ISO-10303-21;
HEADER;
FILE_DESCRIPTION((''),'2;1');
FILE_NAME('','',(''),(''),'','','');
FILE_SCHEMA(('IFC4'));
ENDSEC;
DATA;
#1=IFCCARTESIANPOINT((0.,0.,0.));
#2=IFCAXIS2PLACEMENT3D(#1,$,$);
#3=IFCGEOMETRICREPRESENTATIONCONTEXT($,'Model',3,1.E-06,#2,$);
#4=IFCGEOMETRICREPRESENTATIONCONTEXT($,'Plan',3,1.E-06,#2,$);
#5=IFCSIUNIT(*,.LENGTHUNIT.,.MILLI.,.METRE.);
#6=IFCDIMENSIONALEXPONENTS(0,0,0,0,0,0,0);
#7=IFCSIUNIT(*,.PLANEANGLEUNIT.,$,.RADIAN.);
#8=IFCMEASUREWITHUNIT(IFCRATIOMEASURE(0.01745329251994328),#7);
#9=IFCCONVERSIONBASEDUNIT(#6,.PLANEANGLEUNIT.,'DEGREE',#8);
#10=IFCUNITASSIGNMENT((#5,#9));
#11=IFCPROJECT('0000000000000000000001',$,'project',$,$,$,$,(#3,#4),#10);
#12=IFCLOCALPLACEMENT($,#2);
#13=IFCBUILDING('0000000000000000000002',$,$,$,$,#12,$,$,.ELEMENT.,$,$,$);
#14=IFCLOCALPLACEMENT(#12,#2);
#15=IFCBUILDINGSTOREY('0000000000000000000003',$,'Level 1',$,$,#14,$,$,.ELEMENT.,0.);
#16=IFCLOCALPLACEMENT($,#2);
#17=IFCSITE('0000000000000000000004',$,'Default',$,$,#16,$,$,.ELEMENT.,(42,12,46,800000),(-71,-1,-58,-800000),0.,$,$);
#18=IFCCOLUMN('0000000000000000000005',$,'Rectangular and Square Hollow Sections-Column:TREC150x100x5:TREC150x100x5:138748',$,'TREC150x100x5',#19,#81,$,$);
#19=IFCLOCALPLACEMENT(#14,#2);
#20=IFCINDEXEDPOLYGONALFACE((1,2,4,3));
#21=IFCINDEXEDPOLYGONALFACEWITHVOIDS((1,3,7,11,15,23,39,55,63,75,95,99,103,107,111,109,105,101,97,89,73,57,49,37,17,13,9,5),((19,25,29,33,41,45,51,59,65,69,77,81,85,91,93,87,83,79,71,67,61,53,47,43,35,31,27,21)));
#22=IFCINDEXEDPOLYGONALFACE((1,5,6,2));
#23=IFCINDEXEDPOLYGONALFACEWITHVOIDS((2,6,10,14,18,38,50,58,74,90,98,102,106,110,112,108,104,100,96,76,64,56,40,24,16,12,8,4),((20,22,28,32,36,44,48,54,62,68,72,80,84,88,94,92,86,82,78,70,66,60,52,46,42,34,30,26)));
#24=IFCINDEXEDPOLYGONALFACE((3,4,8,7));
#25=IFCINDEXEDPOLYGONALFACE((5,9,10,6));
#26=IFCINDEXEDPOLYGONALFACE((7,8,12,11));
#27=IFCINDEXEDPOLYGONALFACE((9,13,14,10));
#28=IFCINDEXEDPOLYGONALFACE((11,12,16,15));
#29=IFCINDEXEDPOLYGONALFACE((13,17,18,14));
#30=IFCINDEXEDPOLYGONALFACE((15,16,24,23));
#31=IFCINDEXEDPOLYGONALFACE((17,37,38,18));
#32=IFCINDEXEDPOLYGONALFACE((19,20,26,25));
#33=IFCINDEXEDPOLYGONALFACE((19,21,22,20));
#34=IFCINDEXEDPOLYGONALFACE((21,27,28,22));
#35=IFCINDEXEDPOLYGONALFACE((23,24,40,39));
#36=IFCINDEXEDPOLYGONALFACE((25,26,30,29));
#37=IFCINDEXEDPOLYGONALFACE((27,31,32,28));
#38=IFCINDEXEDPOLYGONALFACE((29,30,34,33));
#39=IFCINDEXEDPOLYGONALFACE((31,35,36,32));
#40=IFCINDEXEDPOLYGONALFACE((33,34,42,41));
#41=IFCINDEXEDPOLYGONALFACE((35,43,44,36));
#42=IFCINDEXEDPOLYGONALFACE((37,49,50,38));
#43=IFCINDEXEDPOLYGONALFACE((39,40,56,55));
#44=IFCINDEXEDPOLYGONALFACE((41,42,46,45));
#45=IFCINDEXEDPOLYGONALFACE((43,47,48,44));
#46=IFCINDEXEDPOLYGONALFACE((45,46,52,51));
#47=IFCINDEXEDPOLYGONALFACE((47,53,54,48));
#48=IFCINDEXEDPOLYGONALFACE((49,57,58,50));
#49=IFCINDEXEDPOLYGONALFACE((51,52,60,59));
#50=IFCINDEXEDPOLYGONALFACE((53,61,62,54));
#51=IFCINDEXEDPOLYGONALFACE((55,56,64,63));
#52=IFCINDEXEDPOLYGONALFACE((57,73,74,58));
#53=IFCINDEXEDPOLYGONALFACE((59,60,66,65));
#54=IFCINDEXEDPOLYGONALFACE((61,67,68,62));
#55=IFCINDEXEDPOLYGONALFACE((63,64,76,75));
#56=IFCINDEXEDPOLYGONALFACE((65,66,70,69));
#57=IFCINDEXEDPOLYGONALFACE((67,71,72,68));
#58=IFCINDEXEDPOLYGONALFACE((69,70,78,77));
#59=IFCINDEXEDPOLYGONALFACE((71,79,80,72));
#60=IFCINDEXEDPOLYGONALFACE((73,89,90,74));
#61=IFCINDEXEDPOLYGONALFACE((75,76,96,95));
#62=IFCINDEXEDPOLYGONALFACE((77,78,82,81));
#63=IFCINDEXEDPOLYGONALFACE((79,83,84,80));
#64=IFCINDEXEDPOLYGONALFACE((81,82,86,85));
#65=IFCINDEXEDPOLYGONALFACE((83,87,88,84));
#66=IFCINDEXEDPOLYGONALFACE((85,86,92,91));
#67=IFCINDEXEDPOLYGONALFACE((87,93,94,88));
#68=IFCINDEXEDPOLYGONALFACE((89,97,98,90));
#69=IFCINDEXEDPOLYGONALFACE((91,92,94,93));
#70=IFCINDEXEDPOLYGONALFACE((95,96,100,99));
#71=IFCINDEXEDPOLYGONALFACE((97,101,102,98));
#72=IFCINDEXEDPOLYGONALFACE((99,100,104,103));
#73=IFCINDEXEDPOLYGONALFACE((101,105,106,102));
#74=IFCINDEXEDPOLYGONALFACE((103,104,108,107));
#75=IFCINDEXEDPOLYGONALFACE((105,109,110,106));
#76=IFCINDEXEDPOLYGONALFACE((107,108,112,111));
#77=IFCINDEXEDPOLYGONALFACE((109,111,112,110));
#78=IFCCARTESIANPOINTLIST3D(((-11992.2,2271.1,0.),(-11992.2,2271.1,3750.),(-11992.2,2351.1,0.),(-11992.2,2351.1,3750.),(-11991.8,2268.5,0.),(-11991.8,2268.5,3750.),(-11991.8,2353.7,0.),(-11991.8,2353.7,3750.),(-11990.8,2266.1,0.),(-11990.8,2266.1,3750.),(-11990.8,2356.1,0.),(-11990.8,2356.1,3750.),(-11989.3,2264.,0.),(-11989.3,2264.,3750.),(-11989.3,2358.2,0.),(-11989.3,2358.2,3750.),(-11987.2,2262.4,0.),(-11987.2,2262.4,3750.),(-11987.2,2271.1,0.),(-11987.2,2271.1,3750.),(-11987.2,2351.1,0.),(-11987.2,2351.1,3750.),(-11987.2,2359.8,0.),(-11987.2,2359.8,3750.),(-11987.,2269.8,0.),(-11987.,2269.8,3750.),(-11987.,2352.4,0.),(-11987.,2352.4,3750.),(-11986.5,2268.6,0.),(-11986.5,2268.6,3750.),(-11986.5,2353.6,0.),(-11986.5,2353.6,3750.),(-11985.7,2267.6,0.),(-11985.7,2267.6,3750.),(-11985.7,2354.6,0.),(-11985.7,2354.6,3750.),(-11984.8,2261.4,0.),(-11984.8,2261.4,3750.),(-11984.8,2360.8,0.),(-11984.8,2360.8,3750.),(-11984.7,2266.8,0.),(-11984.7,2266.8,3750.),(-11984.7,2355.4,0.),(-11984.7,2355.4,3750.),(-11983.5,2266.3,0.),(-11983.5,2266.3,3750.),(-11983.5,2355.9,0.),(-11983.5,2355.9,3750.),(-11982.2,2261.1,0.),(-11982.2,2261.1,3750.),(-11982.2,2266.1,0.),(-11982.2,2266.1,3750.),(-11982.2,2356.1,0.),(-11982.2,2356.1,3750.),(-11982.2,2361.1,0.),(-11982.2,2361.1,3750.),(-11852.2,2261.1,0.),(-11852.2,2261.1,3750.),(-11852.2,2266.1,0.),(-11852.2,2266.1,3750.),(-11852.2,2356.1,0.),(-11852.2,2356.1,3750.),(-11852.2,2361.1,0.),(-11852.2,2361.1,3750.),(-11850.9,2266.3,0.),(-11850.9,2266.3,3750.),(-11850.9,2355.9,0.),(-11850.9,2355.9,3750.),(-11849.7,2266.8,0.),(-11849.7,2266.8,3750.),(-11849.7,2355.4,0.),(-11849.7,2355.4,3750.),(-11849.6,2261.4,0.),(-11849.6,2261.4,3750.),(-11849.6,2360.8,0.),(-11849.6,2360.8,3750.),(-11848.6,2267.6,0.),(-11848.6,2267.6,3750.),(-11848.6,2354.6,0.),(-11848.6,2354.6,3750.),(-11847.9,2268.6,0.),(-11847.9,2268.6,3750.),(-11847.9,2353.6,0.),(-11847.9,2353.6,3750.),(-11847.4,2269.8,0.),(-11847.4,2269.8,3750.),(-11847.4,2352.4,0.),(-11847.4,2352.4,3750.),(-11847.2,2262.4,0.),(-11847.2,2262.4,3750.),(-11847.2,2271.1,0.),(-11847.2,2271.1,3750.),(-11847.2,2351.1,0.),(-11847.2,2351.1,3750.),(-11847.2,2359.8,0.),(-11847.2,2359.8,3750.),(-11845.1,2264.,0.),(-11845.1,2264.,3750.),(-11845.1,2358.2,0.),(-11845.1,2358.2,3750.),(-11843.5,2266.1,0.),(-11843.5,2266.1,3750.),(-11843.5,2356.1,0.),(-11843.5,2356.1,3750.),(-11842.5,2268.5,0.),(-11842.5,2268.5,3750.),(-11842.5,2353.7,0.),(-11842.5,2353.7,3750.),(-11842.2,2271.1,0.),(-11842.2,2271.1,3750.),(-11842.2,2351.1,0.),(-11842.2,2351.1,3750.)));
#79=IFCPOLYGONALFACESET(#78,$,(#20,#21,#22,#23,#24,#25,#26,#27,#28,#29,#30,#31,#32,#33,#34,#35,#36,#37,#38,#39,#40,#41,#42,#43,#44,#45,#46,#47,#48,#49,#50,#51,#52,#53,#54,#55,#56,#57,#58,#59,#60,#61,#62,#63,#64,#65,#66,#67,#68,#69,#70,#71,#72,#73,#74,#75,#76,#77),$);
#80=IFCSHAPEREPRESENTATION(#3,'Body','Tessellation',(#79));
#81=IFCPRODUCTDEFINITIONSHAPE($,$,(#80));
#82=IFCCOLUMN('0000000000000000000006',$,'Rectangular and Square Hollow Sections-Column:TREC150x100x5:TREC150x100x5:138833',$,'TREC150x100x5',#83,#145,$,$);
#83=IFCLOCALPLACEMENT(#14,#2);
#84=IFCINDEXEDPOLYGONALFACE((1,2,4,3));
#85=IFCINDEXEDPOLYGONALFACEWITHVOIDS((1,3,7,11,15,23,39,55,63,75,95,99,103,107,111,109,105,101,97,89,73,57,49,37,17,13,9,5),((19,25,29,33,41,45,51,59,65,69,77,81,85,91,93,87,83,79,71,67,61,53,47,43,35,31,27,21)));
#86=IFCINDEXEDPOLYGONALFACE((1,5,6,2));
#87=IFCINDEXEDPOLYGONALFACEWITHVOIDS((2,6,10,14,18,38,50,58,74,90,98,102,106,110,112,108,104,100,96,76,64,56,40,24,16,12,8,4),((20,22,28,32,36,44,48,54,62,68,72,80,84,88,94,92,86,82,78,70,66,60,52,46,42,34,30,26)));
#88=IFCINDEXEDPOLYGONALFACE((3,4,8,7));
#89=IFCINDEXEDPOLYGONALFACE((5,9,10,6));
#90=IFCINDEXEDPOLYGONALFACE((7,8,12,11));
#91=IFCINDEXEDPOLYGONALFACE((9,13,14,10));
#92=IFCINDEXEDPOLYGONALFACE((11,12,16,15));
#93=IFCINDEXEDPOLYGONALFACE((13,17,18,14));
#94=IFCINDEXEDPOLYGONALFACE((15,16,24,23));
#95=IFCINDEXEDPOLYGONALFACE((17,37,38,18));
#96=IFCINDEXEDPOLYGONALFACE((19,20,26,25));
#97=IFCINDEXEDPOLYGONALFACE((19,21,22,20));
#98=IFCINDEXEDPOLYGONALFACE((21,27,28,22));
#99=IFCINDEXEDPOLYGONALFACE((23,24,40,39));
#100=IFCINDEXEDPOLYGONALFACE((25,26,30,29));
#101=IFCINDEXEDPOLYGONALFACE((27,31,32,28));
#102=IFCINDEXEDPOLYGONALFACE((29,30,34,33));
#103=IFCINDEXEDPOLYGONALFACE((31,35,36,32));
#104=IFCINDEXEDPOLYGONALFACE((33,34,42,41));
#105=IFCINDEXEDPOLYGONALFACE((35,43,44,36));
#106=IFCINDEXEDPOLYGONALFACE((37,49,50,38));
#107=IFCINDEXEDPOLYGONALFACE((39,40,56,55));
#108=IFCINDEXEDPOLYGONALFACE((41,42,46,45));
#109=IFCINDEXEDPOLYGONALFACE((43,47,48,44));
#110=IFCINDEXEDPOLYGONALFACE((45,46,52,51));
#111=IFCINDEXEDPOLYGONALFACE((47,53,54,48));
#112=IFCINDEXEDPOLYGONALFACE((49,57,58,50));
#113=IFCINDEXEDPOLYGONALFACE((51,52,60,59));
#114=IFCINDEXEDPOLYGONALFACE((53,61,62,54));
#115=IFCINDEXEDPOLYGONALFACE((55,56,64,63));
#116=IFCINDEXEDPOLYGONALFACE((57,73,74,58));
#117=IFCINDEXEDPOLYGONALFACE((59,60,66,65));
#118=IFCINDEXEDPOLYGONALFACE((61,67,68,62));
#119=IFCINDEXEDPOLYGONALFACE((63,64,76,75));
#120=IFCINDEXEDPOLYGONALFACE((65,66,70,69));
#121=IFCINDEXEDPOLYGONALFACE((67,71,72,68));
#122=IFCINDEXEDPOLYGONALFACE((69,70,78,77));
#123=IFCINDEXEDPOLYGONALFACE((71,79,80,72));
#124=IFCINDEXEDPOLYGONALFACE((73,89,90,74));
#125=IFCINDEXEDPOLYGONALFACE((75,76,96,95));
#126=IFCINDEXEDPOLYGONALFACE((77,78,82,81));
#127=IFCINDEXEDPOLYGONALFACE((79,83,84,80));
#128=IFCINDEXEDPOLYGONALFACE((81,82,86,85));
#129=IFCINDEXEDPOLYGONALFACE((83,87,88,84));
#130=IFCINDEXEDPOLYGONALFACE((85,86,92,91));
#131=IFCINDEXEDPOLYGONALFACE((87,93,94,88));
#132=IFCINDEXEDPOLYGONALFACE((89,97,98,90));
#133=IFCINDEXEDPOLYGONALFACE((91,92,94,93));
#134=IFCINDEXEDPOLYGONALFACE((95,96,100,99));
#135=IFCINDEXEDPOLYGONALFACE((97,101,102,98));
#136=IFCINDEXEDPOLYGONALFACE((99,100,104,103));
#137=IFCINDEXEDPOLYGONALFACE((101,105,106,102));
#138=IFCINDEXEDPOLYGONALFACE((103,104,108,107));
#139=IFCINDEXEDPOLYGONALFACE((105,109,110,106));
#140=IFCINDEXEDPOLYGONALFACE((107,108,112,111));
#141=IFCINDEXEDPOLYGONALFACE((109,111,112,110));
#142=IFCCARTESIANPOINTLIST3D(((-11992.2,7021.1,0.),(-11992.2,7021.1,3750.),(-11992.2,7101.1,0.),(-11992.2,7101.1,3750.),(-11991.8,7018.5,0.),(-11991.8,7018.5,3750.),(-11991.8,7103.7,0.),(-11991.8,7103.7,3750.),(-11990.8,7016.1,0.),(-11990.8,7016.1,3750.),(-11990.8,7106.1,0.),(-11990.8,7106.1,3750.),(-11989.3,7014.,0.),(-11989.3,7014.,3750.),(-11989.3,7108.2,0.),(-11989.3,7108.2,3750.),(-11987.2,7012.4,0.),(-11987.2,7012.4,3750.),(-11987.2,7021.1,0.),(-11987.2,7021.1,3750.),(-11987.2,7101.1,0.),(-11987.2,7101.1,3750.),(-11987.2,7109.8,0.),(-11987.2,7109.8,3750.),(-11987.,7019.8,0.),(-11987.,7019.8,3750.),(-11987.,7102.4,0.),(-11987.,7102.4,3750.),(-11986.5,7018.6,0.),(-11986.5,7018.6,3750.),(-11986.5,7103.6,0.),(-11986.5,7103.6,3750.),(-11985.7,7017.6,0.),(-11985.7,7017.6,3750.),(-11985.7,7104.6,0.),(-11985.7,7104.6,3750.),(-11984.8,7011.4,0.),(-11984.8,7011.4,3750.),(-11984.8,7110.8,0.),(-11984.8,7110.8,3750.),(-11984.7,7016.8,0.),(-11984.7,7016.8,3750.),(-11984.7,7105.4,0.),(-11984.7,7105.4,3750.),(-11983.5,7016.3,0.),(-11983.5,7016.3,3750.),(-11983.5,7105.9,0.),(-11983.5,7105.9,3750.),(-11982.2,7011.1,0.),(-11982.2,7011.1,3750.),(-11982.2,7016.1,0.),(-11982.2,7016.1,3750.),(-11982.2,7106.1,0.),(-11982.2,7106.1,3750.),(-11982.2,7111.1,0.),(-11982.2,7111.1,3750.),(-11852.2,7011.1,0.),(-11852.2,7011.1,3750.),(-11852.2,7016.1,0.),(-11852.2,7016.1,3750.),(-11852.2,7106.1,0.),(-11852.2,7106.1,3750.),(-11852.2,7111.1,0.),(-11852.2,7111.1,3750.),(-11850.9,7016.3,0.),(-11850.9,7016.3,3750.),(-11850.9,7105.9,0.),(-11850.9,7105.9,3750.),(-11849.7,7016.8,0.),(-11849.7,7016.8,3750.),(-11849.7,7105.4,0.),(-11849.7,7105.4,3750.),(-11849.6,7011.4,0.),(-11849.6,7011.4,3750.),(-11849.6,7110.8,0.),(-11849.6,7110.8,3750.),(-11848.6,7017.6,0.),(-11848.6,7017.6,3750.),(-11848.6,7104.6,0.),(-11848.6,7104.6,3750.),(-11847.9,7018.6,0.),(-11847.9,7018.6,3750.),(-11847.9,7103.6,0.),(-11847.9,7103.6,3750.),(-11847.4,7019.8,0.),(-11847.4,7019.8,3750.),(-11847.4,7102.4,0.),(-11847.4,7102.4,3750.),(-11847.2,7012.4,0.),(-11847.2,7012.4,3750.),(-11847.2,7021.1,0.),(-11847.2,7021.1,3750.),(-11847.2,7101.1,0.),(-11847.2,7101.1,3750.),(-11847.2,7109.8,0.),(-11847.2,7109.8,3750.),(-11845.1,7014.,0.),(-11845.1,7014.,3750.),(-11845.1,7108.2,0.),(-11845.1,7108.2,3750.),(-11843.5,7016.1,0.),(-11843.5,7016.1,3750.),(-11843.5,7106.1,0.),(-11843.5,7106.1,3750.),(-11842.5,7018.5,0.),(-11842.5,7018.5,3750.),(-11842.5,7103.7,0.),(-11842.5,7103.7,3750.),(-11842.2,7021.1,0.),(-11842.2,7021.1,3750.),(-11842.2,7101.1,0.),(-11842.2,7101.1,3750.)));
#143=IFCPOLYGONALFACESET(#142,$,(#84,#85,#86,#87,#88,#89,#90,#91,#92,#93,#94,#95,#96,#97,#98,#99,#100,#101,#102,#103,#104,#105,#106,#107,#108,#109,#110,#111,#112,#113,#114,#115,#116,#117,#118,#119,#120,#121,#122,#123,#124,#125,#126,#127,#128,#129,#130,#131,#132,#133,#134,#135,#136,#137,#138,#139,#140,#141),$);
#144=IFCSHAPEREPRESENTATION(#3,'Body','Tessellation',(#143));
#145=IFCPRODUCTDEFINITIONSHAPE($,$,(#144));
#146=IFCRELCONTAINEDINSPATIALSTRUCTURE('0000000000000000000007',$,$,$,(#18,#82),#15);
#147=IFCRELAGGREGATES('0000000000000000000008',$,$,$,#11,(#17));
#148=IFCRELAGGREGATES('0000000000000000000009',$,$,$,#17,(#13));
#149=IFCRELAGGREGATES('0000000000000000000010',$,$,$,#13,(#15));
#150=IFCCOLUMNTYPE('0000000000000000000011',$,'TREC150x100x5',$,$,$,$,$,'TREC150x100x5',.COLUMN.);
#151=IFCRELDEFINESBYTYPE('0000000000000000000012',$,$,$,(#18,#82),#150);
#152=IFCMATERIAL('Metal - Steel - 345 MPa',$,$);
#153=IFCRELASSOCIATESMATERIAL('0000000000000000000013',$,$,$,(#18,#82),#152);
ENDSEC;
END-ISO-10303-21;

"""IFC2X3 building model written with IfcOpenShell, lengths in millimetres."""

from ifc_helpers import new_model, entity, si_unit, converted_unit, frame, frame_2d, origin, place, context, project, spatial, polyline, circle_curve, parameter, trimmed, segment, composite_curve, outline, extrude, source, transform, mapped, material, type_object, type_shapes, element, save


model = new_model("IFC2X3")

# Units and contexts
model_context = context("Model", 3, precision=1e-06, world=origin())
plan_context = context("Plan", 3, precision=1e-06, world=origin())
ifc_project = project(units=[si_unit("LENGTHUNIT", "METRE", prefix="MILLI"), converted_unit("PLANEANGLEUNIT", "DEGREE", entity("IfcRatioMeasure", 0.01745329251994328), si_unit("PLANEANGLEUNIT", "RADIAN"), dimensions=[0, 0, 0, 0, 0, 0, 0])], contexts=[model_context, plan_context])

# Site, building, storey
site_placement = place(None, origin())
site = spatial("IfcSite", under=ifc_project, at=site_placement, Name="Default", CompositionType="ELEMENT", RefLatitude=(42, 12, 46, 800000), RefLongitude=(-71, -1, -58, -800000), RefElevation=0.0)
building_placement = place(None, origin())
building = spatial("IfcBuilding", under=site, at=building_placement, CompositionType="ELEMENT")
storey_placement = place(building_placement, origin())
storey = spatial("IfcBuildingStorey", under=building, at=storey_placement, Name="Level 1", CompositionType="ELEMENT", Elevation=0.0)

# Columns
ifc_material_1 = material(Name="Metal - Steel - 345 MPa")
column_type_1 = type_object("IfcColumnType", Name="TREC150x100x5", ElementType="TREC150x100x5", PredefinedType="COLUMN")
shared_shape_1 = source(origin(), model_context, "Body", "SweptSolid", [
    extrude(outline(composite_curve([segment(polyline([(-40.0, -75.0), (40.0, -75.0)]), True, "CONTINUOUS"), segment(trimmed(circle_curve(frame_2d((40.0, -65.0), x_axis=(-1.0, 0.0)), 10.0), [parameter(90.0)], [parameter(180.0)], True, "PARAMETER"), True, "CONTINUOUS"), segment(polyline([(50.0, -65.0), (50.0, 65.0)]), True, "CONTINUOUS"), segment(trimmed(circle_curve(frame_2d((40.0, 65.0), x_axis=(-1.0, 0.0)), 10.0), [parameter(180.0)], [parameter(270.0)], True, "PARAMETER"), True, "CONTINUOUS"), segment(polyline([(40.0, 75.0), (-40.0, 75.0)]), True, "CONTINUOUS"), segment(trimmed(circle_curve(frame_2d((-40.0, 65.0), x_axis=(-1.0, 0.0)), 10.0), [parameter(270.0)], [parameter(360.0)], True, "PARAMETER"), True, "CONTINUOUS"), segment(polyline([(-50.0, 65.0), (-50.0, -65.0)]), True, "CONTINUOUS"), segment(trimmed(circle_curve(frame_2d((-40.0, -65.0), x_axis=(-1.0, 0.0)), 10.0), [parameter(360.0)], [parameter(90.0)], True, "PARAMETER"), True, "CONTINUOUS")], self_intersect=False), holes=[composite_curve([segment(trimmed(circle_curve(frame_2d((-40.0, -65.0), x_axis=(-1.0, 0.0)), 5.0), [parameter(0.0)], [parameter(90.0)], True, "PARAMETER"), False, "CONTINUOUS"), segment(polyline([(-45.0, -65.0), (-45.0, 65.0)]), True, "CONTINUOUS"), segment(trimmed(circle_curve(frame_2d((-40.0, 65.0), x_axis=(-1.0, 0.0)), 5.0), [parameter(270.0)], [parameter(360.0)], True, "PARAMETER"), False, "CONTINUOUS"), segment(polyline([(-40.0, 70.0), (40.0, 70.0)]), True, "CONTINUOUS"), segment(trimmed(circle_curve(frame_2d((40.0, 65.0), x_axis=(-1.0, 0.0)), 5.0), [parameter(180.0)], [parameter(270.0)], True, "PARAMETER"), False, "CONTINUOUS"), segment(polyline([(45.0, 65.0), (45.0, -65.0)]), True, "CONTINUOUS"), segment(trimmed(circle_curve(frame_2d((40.0, -65.0), x_axis=(-1.0, 0.0)), 5.0), [parameter(90.0)], [parameter(180.0)], True, "PARAMETER"), False, "CONTINUOUS"), segment(polyline([(40.0, -70.0), (-40.0, -70.0)]), True, "CONTINUOUS")], self_intersect=False)]), frame((0.0, 0.0, 0.0), z_axis=(0.0, 0.0, 1.0), x_axis=(-1.0, 0.0, 0.0)), (0.0, 0.0, 1.0), 3750.0),
])
type_shapes(column_type_1, [shared_shape_1])
for number, where, z_axis, x_axis, name in (
    (1, (-11917.2, 2311.1, 0.0), (0.0, 0.0, 1.0), (0.0, 1.0, 0.0), "Rectangular and Square Hollow Sections-Column:TREC150x100x5:TREC150x100x5:138748"),
    (2, (-11917.2, 7061.1, 0.0), (0.0, 0.0, 1.0), (0.0, 1.0, 0.0), "Rectangular and Square Hollow Sections-Column:TREC150x100x5:TREC150x100x5:138833"),
):
    element("IfcColumn", number, at=place(storey_placement, frame(where, z_axis=z_axis, x_axis=x_axis)), inside=storey, type_object=column_type_1, material=ifc_material_1, Name=name, ObjectType="TREC150x100x5", context=model_context, shape_type="MappedRepresentation", body=[
        mapped(shared_shape_1, transform((0.0, 0.0, 0.0), scale=1.0)),
    ])

save(model, "model.ifc")
